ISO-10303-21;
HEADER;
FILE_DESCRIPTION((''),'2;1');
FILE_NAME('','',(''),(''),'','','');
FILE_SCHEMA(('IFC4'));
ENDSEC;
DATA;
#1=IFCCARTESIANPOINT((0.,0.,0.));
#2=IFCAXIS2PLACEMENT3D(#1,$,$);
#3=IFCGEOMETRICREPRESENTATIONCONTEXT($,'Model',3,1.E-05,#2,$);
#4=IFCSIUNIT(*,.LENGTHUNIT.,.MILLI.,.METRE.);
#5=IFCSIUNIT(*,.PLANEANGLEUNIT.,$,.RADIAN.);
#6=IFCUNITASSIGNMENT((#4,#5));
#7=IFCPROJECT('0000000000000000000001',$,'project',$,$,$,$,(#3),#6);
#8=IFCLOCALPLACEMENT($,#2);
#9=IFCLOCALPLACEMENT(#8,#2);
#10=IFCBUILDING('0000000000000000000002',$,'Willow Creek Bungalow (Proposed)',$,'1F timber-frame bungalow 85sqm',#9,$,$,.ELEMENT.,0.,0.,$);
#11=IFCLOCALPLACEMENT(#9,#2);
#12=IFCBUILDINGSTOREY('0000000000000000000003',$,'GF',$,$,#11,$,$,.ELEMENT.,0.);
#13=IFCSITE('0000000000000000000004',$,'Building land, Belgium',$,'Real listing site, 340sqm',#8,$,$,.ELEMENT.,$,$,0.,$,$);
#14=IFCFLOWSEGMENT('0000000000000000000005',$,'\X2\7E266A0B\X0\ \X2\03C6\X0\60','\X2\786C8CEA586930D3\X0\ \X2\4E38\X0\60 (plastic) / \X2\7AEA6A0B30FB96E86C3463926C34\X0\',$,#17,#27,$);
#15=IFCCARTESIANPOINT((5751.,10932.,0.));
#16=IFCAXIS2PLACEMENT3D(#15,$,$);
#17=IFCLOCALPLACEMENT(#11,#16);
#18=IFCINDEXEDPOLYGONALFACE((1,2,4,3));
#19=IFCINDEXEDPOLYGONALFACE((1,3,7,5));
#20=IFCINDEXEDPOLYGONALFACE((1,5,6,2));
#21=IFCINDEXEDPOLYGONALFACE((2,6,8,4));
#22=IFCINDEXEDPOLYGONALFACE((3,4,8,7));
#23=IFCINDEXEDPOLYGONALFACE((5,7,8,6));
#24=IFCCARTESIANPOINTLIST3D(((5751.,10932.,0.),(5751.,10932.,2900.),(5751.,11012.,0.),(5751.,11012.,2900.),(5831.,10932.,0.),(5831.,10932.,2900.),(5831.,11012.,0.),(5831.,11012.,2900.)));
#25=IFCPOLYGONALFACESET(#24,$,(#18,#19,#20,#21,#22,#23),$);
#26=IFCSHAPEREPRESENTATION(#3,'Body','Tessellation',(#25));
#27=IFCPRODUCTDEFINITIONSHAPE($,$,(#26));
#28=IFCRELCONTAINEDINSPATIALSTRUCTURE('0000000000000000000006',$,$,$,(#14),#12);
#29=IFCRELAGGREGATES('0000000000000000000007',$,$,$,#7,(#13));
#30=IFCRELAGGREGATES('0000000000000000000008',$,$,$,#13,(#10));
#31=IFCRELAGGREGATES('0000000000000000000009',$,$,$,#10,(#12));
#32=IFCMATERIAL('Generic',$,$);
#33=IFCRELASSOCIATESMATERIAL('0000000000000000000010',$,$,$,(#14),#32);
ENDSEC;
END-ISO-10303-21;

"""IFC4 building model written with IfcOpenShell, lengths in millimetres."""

from ifc_helpers import new_model, si_unit, frame, frame_2d, origin, place, context, project, spatial, rectangle, extrude, material, element, save


model = new_model("IFC4")

# Units and contexts
model_context = context("Model", 3, precision=1e-05, world=origin())
ifc_project = project(units=[si_unit("LENGTHUNIT", "METRE", prefix="MILLI"), si_unit("PLANEANGLEUNIT", "RADIAN")], contexts=[model_context])

# Site, building, storey
site_placement = place(None, origin())
site = spatial("IfcSite", under=ifc_project, at=site_placement, Name="Building land, Belgium", ObjectType="Real listing site, 340sqm", CompositionType="ELEMENT", RefElevation=0.0)
building_placement = place(site_placement, origin())
building = spatial("IfcBuilding", under=site, at=building_placement, Name="Willow Creek Bungalow (Proposed)", ObjectType="1F timber-frame bungalow 85sqm", CompositionType="ELEMENT", ElevationOfRefHeight=0.0, ElevationOfTerrain=0.0)
storey_placement = place(building_placement, origin())
storey = spatial("IfcBuildingStorey", under=building, at=storey_placement, Name="GF", CompositionType="ELEMENT", Elevation=0.0)

# Shared definitions
ifc_material_1 = material(Name="Generic")

# Flow segment
flow_segment_1_placement = place(storey_placement, frame((5751.0, 10932.0, 0.0)))
element("IfcFlowSegment", 1, at=flow_segment_1_placement, inside=storey, material=ifc_material_1, Name="縦樋 φ60", Description="硬質塩ビ 丸60 (plastic) / 竪樋・雨水排水", context=model_context, shape_type="SweptSolid", body=[
    extrude(rectangle(XDim=80.0, YDim=80.0, at=frame_2d((40.0, 40.0))), frame((5751.0, 10932.0, 0.0)), (0.0, 0.0, 1.0), 2900.0),
])

save(model, "model.ifc")
